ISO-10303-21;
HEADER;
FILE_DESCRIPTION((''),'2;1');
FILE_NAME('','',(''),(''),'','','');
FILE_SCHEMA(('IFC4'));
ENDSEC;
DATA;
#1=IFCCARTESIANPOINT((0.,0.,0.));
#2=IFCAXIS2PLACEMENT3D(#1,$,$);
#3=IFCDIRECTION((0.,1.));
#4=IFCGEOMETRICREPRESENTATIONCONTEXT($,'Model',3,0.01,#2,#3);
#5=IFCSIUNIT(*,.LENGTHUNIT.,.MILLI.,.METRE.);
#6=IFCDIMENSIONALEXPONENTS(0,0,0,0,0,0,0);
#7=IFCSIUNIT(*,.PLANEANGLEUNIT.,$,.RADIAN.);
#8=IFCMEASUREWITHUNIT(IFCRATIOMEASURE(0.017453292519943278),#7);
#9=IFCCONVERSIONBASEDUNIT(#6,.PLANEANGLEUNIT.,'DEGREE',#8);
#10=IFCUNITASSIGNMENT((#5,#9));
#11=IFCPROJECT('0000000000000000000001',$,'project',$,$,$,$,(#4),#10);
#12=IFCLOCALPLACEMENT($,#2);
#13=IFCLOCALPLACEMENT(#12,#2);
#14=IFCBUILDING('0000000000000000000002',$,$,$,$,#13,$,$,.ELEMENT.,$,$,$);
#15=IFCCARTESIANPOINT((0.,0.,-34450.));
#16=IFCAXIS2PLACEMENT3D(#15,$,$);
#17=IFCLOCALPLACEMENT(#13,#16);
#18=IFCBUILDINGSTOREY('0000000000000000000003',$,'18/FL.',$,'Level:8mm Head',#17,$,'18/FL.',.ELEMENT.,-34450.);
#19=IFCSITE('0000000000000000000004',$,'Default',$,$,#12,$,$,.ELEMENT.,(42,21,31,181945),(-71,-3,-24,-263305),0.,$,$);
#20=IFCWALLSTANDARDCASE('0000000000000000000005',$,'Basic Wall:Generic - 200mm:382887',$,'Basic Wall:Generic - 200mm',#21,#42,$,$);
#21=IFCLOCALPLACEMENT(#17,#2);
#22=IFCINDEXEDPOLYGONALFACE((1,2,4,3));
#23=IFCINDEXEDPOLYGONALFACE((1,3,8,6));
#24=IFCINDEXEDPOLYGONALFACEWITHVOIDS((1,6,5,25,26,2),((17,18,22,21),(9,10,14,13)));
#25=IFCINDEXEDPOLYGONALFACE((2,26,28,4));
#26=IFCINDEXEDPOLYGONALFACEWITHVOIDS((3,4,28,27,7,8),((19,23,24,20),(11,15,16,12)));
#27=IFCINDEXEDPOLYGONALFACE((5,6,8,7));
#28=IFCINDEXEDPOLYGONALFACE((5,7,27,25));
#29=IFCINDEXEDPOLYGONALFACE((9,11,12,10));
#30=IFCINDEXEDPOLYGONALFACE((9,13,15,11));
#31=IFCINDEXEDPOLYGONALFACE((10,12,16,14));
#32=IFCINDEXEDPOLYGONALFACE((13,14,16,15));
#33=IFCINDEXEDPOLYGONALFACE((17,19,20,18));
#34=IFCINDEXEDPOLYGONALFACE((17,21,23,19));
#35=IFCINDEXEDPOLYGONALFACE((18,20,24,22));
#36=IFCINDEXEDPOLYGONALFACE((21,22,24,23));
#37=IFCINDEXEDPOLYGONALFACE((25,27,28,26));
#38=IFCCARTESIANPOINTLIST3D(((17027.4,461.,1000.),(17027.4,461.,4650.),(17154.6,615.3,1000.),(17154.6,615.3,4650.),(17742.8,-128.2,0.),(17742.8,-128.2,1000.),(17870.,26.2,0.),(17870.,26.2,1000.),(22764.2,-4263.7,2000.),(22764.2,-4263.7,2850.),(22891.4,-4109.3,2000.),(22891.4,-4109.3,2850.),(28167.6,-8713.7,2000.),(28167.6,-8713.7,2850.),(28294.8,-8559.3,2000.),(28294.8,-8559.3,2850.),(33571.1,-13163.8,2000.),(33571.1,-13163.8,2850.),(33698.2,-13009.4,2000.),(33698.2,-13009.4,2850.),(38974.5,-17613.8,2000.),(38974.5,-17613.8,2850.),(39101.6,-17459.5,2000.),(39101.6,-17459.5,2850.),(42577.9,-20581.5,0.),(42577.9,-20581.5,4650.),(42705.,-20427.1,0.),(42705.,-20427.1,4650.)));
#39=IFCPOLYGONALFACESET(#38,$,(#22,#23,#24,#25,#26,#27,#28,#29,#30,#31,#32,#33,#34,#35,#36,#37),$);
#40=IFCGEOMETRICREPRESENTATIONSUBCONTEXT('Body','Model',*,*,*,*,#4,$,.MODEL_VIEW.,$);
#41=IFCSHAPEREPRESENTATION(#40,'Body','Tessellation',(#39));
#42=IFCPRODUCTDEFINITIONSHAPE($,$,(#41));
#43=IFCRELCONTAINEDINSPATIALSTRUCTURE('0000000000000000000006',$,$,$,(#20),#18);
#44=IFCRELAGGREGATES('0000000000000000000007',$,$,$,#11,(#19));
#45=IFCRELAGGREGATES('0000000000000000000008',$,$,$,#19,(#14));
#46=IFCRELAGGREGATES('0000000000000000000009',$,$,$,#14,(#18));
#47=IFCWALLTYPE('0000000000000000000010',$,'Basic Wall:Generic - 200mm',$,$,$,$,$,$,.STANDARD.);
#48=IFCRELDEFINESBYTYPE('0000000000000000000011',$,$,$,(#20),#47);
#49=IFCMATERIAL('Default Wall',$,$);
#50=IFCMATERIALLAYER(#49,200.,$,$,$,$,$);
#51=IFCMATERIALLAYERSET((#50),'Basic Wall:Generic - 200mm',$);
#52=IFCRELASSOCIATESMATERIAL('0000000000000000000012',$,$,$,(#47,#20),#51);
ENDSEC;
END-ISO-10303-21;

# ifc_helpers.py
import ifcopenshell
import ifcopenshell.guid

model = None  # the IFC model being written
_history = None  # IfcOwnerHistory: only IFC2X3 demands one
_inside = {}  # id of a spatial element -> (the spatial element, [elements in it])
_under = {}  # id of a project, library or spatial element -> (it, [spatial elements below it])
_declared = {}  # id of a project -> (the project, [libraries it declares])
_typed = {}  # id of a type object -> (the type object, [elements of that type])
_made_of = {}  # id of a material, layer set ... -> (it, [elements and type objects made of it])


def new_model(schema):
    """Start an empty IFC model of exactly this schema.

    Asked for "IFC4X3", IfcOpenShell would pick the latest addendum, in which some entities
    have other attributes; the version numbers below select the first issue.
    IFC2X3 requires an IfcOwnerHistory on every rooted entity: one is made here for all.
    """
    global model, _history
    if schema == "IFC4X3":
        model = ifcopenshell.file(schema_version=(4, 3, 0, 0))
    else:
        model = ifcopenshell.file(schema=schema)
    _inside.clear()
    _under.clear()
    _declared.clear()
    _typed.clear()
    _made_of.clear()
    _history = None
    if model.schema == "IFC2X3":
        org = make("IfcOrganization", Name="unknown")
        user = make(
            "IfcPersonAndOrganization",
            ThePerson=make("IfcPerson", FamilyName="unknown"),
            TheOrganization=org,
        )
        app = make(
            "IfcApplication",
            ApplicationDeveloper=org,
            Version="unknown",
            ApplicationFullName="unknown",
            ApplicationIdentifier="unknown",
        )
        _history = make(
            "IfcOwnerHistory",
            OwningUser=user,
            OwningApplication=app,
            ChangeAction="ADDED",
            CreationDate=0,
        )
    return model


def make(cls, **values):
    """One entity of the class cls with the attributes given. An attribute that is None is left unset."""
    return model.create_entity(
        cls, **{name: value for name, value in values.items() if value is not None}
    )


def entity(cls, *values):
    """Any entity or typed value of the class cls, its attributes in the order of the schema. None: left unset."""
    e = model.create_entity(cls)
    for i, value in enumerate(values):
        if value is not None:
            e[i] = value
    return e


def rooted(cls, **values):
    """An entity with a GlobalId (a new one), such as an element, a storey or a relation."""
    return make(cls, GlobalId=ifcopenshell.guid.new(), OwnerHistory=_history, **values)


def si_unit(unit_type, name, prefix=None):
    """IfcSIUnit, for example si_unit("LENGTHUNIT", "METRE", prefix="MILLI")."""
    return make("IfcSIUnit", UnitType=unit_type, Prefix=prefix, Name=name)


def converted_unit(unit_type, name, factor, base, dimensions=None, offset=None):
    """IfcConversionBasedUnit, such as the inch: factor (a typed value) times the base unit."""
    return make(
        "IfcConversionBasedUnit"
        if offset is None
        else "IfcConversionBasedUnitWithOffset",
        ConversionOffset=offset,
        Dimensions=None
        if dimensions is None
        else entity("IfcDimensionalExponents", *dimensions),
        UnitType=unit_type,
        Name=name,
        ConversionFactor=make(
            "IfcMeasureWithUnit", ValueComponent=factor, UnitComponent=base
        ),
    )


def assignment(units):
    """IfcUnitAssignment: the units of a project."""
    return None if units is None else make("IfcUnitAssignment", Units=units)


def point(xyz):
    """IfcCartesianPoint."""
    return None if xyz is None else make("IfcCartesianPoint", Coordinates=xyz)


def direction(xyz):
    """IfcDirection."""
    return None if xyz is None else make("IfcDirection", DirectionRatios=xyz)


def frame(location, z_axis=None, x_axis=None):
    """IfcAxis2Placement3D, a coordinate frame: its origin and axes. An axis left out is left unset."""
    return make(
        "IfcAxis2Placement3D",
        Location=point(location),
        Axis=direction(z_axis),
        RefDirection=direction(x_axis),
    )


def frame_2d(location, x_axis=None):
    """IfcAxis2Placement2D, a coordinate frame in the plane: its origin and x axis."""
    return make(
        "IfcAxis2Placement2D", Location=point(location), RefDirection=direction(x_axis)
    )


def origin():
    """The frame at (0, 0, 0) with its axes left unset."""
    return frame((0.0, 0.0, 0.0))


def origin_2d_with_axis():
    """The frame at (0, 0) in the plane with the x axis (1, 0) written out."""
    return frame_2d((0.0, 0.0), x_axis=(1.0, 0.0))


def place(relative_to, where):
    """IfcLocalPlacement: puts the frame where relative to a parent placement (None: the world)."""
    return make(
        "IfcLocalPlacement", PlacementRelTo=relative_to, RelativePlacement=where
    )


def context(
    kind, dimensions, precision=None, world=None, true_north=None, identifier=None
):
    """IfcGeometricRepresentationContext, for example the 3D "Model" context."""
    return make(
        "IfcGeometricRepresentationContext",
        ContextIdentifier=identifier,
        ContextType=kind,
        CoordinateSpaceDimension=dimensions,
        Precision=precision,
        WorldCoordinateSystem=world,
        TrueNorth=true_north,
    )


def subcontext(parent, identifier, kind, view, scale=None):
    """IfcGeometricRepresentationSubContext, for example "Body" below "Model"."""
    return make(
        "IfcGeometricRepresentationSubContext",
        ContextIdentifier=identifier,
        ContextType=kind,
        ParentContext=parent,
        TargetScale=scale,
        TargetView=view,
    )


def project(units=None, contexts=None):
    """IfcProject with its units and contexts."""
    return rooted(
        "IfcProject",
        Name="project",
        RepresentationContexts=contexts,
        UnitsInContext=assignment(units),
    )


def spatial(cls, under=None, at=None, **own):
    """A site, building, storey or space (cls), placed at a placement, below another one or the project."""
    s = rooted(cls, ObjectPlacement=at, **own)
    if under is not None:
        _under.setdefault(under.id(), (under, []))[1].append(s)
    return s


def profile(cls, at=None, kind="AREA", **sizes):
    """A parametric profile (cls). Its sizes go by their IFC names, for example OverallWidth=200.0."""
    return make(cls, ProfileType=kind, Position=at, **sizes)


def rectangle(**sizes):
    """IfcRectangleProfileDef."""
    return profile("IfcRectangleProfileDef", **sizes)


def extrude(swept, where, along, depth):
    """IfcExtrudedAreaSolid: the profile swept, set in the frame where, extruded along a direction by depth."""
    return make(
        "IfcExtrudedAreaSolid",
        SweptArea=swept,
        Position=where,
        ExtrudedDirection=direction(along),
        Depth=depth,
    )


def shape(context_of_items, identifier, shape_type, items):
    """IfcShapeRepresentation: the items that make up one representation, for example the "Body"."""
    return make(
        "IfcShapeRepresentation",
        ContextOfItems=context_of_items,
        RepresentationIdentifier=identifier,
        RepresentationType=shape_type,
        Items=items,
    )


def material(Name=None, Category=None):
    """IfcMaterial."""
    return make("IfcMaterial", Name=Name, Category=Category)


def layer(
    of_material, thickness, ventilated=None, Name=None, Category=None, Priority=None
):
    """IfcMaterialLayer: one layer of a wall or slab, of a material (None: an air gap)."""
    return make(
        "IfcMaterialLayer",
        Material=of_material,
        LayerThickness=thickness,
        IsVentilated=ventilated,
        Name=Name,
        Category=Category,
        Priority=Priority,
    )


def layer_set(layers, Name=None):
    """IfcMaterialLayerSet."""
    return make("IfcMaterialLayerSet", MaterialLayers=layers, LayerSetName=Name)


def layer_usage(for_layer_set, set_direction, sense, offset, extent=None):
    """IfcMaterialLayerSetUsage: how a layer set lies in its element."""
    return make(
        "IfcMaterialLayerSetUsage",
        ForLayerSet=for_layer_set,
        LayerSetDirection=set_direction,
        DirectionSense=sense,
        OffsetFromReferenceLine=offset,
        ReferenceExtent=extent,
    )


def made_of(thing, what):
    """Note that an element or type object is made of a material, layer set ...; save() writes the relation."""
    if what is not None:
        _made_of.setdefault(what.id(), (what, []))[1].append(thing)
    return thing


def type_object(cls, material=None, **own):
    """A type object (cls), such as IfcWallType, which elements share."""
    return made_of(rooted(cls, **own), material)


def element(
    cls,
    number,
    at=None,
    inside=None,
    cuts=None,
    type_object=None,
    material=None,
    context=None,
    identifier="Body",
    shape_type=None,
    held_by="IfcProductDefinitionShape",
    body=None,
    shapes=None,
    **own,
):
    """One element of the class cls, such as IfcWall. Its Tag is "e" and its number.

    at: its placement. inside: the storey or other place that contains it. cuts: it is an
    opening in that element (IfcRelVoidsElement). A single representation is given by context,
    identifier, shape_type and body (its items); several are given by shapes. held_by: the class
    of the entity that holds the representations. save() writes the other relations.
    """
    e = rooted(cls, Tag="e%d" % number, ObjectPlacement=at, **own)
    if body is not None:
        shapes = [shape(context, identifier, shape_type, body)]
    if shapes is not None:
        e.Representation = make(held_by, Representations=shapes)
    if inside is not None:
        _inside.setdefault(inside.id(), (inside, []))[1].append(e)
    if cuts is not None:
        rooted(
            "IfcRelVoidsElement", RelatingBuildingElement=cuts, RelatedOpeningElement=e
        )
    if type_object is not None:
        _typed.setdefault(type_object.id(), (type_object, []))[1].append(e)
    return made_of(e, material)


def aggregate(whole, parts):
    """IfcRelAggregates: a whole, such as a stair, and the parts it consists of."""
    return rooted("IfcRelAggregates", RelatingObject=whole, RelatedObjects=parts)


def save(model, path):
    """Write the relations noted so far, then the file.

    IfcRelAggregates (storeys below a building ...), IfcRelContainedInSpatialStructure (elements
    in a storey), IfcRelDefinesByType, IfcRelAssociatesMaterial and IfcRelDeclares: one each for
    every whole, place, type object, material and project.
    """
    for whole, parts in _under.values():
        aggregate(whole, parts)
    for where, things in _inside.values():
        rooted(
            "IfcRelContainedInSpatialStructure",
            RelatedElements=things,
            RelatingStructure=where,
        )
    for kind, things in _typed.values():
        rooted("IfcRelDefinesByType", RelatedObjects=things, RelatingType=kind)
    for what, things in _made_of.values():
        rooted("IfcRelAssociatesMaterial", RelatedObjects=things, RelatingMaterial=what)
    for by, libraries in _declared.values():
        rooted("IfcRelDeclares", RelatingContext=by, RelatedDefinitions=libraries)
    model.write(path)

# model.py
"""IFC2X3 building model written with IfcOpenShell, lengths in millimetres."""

from ifc_helpers import new_model, entity, si_unit, converted_unit, direction, frame, frame_2d, origin, origin_2d_with_axis, place, context, subcontext, project, spatial, rectangle, extrude, material, layer, layer_set, layer_usage, type_object, element, save


model = new_model("IFC2X3")

# Units and contexts
model_context = context("Model", 3, precision=0.01, world=origin(), true_north=direction((0.0, 1.0)))
body_context = subcontext(model_context, "Body", "Model", "MODEL_VIEW")
ifc_project = project(units=[si_unit("LENGTHUNIT", "METRE", prefix="MILLI"), converted_unit("PLANEANGLEUNIT", "DEGREE", entity("IfcRatioMeasure", 0.017453292519943278), si_unit("PLANEANGLEUNIT", "RADIAN"), dimensions=[0, 0, 0, 0, 0, 0, 0])], contexts=[model_context])

# Site, building, storey
site_placement = place(None, origin())
site = spatial("IfcSite", under=ifc_project, at=site_placement, Name="Default", CompositionType="ELEMENT", RefLatitude=(42, 21, 31, 181945), RefLongitude=(-71, -3, -24, -263305), RefElevation=0.0)
building_placement = place(site_placement, origin())
building = spatial("IfcBuilding", under=site, at=building_placement, CompositionType="ELEMENT")
storey_placement = place(building_placement, frame((0.0, 0.0, -34450.0)))
storey = spatial("IfcBuildingStorey", under=building, at=storey_placement, Name="18/FL.", ObjectType="Level:8mm Head", LongName="18/FL.", CompositionType="ELEMENT", Elevation=-34450.0)

# Wall, openings
ifc_material_1 = material(Name="Default Wall")
ifc_layer = layer(ifc_material_1, 200.0)
ifc_layer_set = layer_set([ifc_layer], Name="Basic Wall:Generic - 200mm")
ifc_layer_usage = layer_usage(ifc_layer_set, "AXIS2", "NEGATIVE", 100.0)
wall_type = type_object("IfcWallType", Name="Basic Wall:Generic - 200mm", PredefinedType="STANDARD", material=ifc_layer_set)
wall_1_placement = place(storey_placement, frame((42641.5, -20504.3, 0.0), z_axis=(0.0, 0.0, 1.0), x_axis=(-0.771917, 0.635723, 0.0)))
wall_1 = element("IfcWallStandardCase", 1, at=wall_1_placement, inside=storey, type_object=wall_type, material=ifc_layer_usage, Name="Basic Wall:Generic - 200mm:382887", ObjectType="Basic Wall:Generic - 200mm", context=body_context, shape_type="SweptSolid", body=[
    extrude(rectangle(XDim=33100.0, YDim=200.0, at=frame_2d((16550.0, 0.0), x_axis=(-1.0, 0.0))), origin(), (0.0, 0.0, 1.0), 4650.0),
])
opening_1_placement = place(wall_1_placement, origin())
element("IfcOpeningElement", 2, at=opening_1_placement, cuts=wall_1, ObjectType="Opening", context=body_context, shape_type="SweptSolid", body=[
    extrude(rectangle(XDim=850.0, YDim=7000.0, at=frame_2d((0.0, 0.0), x_axis=(1.0, 0.0))), frame((8168.1, -100.0, 2425.0), z_axis=(0.0, 1.0, 0.0), x_axis=(0.0, 0.0, -1.0)), (0.0, 0.0, 1.0), 200.0),
])
opening_2_placement = place(wall_1_placement, origin())
element("IfcOpeningElement", 3, at=opening_2_placement, cuts=wall_1, ObjectType="Opening", context=body_context, shape_type="SweptSolid", body=[
    extrude(rectangle(XDim=850.0, YDim=7000.0, at=origin_2d_with_axis()), frame((22168.1, -100.0, 2425.0), z_axis=(0.0, 1.0, 0.0), x_axis=(0.0, 0.0, -1.0)), (0.0, 0.0, 1.0), 200.0),
])
opening_3_placement = place(wall_1_placement, frame((45950.7, 11280.6, 0.0), z_axis=(0.0, 0.0, 1.0), x_axis=(-0.771917, -0.635723, 0.0)))
element("IfcOpeningElement", 4, at=opening_3_placement, cuts=wall_1, ObjectType="Opening", context=body_context, shape_type="SweptSolid", body=[
    extrude(rectangle(XDim=1000.0, YDim=1010.1, at=origin_2d_with_axis()), frame((17488.2, 357.1, 500.0), z_axis=(-0.635723, -0.771917, 0.0), x_axis=(0.0, 0.0, -1.0)), (0.0, 0.0, 1.0), 1012.7),
])

save(model, "model.ifc")
